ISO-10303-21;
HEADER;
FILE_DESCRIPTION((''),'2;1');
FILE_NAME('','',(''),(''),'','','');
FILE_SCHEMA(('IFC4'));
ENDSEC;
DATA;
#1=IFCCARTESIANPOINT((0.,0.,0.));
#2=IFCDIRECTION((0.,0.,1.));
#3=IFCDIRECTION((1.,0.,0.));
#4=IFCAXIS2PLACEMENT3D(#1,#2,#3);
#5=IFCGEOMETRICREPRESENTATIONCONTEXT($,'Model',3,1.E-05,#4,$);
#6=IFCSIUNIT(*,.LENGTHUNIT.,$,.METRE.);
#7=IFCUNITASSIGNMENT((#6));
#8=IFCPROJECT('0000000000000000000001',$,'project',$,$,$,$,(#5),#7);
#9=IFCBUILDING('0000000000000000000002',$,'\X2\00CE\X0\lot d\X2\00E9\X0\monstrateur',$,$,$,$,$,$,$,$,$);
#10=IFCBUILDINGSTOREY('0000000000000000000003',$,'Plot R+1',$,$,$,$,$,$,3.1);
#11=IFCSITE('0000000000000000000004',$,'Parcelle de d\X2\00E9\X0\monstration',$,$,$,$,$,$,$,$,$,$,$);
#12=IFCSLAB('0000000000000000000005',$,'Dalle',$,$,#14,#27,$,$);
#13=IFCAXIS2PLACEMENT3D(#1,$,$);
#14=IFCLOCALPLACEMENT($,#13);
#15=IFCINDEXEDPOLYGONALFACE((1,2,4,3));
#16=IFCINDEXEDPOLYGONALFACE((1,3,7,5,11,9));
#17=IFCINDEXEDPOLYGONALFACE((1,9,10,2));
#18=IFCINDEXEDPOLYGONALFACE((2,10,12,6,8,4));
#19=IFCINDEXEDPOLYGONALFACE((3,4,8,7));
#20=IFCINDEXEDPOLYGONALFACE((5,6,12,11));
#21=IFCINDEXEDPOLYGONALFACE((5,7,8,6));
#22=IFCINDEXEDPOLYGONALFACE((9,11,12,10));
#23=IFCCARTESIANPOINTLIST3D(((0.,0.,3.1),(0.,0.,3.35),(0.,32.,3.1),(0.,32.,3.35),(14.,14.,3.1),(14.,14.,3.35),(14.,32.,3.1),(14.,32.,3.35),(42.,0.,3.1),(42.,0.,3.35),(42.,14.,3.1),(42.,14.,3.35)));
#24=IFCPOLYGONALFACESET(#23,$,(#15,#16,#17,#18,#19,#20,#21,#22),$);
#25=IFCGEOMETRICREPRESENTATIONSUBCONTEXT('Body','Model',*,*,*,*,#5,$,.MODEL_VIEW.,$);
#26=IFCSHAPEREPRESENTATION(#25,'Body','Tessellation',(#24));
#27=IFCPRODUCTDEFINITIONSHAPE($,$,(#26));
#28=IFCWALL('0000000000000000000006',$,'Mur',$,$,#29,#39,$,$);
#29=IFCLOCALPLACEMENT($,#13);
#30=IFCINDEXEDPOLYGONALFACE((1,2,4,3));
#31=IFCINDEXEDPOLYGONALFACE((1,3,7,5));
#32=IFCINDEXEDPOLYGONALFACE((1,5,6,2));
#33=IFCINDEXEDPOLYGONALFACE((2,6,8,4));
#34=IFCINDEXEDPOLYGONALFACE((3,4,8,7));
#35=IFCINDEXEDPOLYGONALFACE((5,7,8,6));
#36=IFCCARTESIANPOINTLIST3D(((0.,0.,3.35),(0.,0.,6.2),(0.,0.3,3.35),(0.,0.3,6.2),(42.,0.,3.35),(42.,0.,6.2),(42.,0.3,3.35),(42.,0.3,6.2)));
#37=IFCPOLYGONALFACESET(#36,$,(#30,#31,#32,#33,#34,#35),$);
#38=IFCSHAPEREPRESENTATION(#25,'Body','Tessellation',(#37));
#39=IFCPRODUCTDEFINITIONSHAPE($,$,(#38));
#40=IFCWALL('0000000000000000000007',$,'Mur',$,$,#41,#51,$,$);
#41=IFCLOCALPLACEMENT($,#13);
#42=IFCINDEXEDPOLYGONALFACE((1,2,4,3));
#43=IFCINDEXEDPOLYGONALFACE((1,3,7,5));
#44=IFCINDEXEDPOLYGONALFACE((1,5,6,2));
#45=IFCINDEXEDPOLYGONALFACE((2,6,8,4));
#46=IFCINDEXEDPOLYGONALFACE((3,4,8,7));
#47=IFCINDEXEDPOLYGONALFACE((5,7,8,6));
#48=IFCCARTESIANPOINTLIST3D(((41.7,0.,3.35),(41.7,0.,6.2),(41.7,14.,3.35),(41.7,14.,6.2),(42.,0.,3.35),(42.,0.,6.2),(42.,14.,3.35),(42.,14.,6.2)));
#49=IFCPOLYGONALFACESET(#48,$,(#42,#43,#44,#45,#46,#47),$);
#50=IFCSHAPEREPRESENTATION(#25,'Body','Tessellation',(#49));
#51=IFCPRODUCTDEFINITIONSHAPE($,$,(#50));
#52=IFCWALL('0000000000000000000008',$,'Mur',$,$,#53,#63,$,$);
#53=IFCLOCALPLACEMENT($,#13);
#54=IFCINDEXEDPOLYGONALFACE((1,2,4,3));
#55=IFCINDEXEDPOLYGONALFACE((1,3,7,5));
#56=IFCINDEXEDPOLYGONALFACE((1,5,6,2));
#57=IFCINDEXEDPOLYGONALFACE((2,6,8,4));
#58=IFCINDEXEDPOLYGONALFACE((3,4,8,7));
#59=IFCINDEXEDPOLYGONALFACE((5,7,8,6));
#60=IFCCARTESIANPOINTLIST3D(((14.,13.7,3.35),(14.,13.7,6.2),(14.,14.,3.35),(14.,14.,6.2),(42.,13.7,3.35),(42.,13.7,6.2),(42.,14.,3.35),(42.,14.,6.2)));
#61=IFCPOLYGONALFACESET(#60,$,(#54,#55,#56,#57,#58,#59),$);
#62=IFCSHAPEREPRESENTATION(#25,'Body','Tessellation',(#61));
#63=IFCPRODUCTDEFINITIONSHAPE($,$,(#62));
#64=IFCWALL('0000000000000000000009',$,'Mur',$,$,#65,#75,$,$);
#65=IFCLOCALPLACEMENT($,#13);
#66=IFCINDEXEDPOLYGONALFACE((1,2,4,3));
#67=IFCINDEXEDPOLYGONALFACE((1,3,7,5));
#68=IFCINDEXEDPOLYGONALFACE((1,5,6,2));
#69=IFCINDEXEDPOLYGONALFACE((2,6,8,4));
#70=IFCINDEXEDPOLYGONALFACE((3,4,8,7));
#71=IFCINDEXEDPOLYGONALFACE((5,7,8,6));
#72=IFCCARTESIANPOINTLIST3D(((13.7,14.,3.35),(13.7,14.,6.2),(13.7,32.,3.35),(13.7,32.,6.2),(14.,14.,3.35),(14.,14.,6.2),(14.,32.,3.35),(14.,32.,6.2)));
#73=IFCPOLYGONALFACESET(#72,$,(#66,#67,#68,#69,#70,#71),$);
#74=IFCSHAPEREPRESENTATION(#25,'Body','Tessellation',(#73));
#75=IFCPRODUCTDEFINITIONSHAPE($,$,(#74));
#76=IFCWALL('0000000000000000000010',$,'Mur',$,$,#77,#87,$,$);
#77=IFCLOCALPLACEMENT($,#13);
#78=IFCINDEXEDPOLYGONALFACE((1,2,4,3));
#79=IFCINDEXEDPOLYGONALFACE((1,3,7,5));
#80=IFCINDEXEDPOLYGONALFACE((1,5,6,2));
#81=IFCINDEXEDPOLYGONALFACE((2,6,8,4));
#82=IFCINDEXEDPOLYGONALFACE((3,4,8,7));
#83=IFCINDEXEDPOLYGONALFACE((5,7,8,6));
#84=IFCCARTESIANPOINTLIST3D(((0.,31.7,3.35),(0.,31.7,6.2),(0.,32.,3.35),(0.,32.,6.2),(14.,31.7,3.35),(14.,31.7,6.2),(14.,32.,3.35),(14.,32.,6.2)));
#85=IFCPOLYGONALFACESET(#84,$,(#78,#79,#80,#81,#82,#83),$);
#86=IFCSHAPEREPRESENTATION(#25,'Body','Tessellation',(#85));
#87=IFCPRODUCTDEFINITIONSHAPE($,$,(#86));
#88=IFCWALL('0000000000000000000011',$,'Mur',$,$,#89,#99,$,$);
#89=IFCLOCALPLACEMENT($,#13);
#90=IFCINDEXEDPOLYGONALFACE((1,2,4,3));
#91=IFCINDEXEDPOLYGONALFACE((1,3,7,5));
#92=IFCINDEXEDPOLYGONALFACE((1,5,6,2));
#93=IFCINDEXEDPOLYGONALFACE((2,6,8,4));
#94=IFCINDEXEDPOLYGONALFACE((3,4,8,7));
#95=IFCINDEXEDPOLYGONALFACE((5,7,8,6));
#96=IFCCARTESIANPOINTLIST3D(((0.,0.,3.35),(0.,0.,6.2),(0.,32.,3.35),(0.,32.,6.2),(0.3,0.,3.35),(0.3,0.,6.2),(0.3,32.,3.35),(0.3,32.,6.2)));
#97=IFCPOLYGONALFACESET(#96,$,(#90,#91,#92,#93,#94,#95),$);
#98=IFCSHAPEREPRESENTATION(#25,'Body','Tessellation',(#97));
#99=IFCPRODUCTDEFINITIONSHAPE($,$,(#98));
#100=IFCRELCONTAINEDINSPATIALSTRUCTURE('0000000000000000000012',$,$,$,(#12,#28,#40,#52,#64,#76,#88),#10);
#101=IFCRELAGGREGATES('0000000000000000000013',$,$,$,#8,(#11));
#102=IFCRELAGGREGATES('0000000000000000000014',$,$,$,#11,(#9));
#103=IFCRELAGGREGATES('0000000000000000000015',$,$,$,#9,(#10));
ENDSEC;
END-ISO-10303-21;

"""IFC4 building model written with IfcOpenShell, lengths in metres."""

from ifc_helpers import new_model, si_unit, frame, origin_with_axes, place, context, subcontext, project, spatial, indexed_curve, outline, extrude, element, save


model = new_model("IFC4")

# Units and contexts
model_context = context("Model", 3, precision=1e-05, world=origin_with_axes())
body_context = subcontext(model_context, "Body", "Model", "MODEL_VIEW")
ifc_project = project(units=[si_unit("LENGTHUNIT", "METRE")], contexts=[model_context])

# Site, building, storey
site = spatial("IfcSite", under=ifc_project, Name="Parcelle de démonstration")
building = spatial("IfcBuilding", under=site, Name="Îlot démonstrateur")
storey = spatial("IfcBuildingStorey", under=building, Name="Plot R+1", Elevation=3.1)

# Slab
slab_placement = place(None, frame((0.0, 0.0, 3.1), z_axis=(0.0, 0.0, 1.0), x_axis=(1.0, 0.0, 0.0)))
element("IfcSlab", 1, at=slab_placement, inside=storey, Name="Dalle", context=body_context, shape_type="SweptSolid", body=[
    extrude(outline(indexed_curve([(0.0, 0.0), (42.0, 0.0), (42.0, 14.0), (14.0, 14.0), (14.0, 32.0), (0.0, 32.0)])), None, (0.0, 0.0, 1.0), 0.25),
])

# Walls
wall_1_placement = place(None, frame((0.0, 0.0, 3.35), z_axis=(0.0, 0.0, 1.0), x_axis=(1.0, 0.0, 0.0)))
element("IfcWall", 2, at=wall_1_placement, inside=storey, Name="Mur", context=body_context, shape_type="SweptSolid", body=[
    extrude(outline(indexed_curve([(0.0, 0.0), (0.0, 0.3), (42.0, 0.3), (42.0, 0.0), (0.0, 0.0)], self_intersect=False)), origin_with_axes(), (0.0, 0.0, 1.0), 2.85),
])
wall_2_placement = place(None, frame((42.0, 0.0, 3.35), z_axis=(0.0, 0.0, 1.0), x_axis=(0.0, 1.0, 0.0)))
element("IfcWall", 3, at=wall_2_placement, inside=storey, Name="Mur", context=body_context, shape_type="SweptSolid", body=[
    extrude(outline(indexed_curve([(0.0, 0.0), (0.0, 0.3), (14.0, 0.3), (14.0, 0.0), (0.0, 0.0)], self_intersect=False)), origin_with_axes(), (0.0, 0.0, 1.0), 2.85),
])
wall_3_placement = place(None, frame((42.0, 14.0, 3.35), z_axis=(0.0, 0.0, 1.0), x_axis=(-1.0, 0.0, 0.0)))
element("IfcWall", 4, at=wall_3_placement, inside=storey, Name="Mur", context=body_context, shape_type="SweptSolid", body=[
    extrude(outline(indexed_curve([(0.0, 0.0), (0.0, 0.3), (28.0, 0.3), (28.0, 0.0), (0.0, 0.0)], self_intersect=False)), origin_with_axes(), (0.0, 0.0, 1.0), 2.85),
])
wall_4_placement = place(None, frame((14.0, 14.0, 3.35), z_axis=(0.0, 0.0, 1.0), x_axis=(0.0, 1.0, 0.0)))
element("IfcWall", 5, at=wall_4_placement, inside=storey, Name="Mur", context=body_context, shape_type="SweptSolid", body=[
    extrude(outline(indexed_curve([(0.0, 0.0), (0.0, 0.3), (18.0, 0.3), (18.0, 0.0), (0.0, 0.0)], self_intersect=False)), origin_with_axes(), (0.0, 0.0, 1.0), 2.85),
])
wall_5_placement = place(None, frame((14.0, 32.0, 3.35), z_axis=(0.0, 0.0, 1.0), x_axis=(-1.0, 0.0, 0.0)))
element("IfcWall", 6, at=wall_5_placement, inside=storey, Name="Mur", context=body_context, shape_type="SweptSolid", body=[
    extrude(outline(indexed_curve([(0.0, 0.0), (0.0, 0.3), (14.0, 0.3), (14.0, 0.0), (0.0, 0.0)], self_intersect=False)), origin_with_axes(), (0.0, 0.0, 1.0), 2.85),
])
wall_6_placement = place(None, frame((0.0, 32.0, 3.35), z_axis=(0.0, 0.0, 1.0), x_axis=(0.0, -1.0, 0.0)))
element("IfcWall", 7, at=wall_6_placement, inside=storey, Name="Mur", context=body_context, shape_type="SweptSolid", body=[
    extrude(outline(indexed_curve([(0.0, 0.0), (0.0, 0.3), (32.0, 0.3), (32.0, 0.0), (0.0, 0.0)], self_intersect=False)), origin_with_axes(), (0.0, 0.0, 1.0), 2.85),
])

save(model, "model.ifc")
